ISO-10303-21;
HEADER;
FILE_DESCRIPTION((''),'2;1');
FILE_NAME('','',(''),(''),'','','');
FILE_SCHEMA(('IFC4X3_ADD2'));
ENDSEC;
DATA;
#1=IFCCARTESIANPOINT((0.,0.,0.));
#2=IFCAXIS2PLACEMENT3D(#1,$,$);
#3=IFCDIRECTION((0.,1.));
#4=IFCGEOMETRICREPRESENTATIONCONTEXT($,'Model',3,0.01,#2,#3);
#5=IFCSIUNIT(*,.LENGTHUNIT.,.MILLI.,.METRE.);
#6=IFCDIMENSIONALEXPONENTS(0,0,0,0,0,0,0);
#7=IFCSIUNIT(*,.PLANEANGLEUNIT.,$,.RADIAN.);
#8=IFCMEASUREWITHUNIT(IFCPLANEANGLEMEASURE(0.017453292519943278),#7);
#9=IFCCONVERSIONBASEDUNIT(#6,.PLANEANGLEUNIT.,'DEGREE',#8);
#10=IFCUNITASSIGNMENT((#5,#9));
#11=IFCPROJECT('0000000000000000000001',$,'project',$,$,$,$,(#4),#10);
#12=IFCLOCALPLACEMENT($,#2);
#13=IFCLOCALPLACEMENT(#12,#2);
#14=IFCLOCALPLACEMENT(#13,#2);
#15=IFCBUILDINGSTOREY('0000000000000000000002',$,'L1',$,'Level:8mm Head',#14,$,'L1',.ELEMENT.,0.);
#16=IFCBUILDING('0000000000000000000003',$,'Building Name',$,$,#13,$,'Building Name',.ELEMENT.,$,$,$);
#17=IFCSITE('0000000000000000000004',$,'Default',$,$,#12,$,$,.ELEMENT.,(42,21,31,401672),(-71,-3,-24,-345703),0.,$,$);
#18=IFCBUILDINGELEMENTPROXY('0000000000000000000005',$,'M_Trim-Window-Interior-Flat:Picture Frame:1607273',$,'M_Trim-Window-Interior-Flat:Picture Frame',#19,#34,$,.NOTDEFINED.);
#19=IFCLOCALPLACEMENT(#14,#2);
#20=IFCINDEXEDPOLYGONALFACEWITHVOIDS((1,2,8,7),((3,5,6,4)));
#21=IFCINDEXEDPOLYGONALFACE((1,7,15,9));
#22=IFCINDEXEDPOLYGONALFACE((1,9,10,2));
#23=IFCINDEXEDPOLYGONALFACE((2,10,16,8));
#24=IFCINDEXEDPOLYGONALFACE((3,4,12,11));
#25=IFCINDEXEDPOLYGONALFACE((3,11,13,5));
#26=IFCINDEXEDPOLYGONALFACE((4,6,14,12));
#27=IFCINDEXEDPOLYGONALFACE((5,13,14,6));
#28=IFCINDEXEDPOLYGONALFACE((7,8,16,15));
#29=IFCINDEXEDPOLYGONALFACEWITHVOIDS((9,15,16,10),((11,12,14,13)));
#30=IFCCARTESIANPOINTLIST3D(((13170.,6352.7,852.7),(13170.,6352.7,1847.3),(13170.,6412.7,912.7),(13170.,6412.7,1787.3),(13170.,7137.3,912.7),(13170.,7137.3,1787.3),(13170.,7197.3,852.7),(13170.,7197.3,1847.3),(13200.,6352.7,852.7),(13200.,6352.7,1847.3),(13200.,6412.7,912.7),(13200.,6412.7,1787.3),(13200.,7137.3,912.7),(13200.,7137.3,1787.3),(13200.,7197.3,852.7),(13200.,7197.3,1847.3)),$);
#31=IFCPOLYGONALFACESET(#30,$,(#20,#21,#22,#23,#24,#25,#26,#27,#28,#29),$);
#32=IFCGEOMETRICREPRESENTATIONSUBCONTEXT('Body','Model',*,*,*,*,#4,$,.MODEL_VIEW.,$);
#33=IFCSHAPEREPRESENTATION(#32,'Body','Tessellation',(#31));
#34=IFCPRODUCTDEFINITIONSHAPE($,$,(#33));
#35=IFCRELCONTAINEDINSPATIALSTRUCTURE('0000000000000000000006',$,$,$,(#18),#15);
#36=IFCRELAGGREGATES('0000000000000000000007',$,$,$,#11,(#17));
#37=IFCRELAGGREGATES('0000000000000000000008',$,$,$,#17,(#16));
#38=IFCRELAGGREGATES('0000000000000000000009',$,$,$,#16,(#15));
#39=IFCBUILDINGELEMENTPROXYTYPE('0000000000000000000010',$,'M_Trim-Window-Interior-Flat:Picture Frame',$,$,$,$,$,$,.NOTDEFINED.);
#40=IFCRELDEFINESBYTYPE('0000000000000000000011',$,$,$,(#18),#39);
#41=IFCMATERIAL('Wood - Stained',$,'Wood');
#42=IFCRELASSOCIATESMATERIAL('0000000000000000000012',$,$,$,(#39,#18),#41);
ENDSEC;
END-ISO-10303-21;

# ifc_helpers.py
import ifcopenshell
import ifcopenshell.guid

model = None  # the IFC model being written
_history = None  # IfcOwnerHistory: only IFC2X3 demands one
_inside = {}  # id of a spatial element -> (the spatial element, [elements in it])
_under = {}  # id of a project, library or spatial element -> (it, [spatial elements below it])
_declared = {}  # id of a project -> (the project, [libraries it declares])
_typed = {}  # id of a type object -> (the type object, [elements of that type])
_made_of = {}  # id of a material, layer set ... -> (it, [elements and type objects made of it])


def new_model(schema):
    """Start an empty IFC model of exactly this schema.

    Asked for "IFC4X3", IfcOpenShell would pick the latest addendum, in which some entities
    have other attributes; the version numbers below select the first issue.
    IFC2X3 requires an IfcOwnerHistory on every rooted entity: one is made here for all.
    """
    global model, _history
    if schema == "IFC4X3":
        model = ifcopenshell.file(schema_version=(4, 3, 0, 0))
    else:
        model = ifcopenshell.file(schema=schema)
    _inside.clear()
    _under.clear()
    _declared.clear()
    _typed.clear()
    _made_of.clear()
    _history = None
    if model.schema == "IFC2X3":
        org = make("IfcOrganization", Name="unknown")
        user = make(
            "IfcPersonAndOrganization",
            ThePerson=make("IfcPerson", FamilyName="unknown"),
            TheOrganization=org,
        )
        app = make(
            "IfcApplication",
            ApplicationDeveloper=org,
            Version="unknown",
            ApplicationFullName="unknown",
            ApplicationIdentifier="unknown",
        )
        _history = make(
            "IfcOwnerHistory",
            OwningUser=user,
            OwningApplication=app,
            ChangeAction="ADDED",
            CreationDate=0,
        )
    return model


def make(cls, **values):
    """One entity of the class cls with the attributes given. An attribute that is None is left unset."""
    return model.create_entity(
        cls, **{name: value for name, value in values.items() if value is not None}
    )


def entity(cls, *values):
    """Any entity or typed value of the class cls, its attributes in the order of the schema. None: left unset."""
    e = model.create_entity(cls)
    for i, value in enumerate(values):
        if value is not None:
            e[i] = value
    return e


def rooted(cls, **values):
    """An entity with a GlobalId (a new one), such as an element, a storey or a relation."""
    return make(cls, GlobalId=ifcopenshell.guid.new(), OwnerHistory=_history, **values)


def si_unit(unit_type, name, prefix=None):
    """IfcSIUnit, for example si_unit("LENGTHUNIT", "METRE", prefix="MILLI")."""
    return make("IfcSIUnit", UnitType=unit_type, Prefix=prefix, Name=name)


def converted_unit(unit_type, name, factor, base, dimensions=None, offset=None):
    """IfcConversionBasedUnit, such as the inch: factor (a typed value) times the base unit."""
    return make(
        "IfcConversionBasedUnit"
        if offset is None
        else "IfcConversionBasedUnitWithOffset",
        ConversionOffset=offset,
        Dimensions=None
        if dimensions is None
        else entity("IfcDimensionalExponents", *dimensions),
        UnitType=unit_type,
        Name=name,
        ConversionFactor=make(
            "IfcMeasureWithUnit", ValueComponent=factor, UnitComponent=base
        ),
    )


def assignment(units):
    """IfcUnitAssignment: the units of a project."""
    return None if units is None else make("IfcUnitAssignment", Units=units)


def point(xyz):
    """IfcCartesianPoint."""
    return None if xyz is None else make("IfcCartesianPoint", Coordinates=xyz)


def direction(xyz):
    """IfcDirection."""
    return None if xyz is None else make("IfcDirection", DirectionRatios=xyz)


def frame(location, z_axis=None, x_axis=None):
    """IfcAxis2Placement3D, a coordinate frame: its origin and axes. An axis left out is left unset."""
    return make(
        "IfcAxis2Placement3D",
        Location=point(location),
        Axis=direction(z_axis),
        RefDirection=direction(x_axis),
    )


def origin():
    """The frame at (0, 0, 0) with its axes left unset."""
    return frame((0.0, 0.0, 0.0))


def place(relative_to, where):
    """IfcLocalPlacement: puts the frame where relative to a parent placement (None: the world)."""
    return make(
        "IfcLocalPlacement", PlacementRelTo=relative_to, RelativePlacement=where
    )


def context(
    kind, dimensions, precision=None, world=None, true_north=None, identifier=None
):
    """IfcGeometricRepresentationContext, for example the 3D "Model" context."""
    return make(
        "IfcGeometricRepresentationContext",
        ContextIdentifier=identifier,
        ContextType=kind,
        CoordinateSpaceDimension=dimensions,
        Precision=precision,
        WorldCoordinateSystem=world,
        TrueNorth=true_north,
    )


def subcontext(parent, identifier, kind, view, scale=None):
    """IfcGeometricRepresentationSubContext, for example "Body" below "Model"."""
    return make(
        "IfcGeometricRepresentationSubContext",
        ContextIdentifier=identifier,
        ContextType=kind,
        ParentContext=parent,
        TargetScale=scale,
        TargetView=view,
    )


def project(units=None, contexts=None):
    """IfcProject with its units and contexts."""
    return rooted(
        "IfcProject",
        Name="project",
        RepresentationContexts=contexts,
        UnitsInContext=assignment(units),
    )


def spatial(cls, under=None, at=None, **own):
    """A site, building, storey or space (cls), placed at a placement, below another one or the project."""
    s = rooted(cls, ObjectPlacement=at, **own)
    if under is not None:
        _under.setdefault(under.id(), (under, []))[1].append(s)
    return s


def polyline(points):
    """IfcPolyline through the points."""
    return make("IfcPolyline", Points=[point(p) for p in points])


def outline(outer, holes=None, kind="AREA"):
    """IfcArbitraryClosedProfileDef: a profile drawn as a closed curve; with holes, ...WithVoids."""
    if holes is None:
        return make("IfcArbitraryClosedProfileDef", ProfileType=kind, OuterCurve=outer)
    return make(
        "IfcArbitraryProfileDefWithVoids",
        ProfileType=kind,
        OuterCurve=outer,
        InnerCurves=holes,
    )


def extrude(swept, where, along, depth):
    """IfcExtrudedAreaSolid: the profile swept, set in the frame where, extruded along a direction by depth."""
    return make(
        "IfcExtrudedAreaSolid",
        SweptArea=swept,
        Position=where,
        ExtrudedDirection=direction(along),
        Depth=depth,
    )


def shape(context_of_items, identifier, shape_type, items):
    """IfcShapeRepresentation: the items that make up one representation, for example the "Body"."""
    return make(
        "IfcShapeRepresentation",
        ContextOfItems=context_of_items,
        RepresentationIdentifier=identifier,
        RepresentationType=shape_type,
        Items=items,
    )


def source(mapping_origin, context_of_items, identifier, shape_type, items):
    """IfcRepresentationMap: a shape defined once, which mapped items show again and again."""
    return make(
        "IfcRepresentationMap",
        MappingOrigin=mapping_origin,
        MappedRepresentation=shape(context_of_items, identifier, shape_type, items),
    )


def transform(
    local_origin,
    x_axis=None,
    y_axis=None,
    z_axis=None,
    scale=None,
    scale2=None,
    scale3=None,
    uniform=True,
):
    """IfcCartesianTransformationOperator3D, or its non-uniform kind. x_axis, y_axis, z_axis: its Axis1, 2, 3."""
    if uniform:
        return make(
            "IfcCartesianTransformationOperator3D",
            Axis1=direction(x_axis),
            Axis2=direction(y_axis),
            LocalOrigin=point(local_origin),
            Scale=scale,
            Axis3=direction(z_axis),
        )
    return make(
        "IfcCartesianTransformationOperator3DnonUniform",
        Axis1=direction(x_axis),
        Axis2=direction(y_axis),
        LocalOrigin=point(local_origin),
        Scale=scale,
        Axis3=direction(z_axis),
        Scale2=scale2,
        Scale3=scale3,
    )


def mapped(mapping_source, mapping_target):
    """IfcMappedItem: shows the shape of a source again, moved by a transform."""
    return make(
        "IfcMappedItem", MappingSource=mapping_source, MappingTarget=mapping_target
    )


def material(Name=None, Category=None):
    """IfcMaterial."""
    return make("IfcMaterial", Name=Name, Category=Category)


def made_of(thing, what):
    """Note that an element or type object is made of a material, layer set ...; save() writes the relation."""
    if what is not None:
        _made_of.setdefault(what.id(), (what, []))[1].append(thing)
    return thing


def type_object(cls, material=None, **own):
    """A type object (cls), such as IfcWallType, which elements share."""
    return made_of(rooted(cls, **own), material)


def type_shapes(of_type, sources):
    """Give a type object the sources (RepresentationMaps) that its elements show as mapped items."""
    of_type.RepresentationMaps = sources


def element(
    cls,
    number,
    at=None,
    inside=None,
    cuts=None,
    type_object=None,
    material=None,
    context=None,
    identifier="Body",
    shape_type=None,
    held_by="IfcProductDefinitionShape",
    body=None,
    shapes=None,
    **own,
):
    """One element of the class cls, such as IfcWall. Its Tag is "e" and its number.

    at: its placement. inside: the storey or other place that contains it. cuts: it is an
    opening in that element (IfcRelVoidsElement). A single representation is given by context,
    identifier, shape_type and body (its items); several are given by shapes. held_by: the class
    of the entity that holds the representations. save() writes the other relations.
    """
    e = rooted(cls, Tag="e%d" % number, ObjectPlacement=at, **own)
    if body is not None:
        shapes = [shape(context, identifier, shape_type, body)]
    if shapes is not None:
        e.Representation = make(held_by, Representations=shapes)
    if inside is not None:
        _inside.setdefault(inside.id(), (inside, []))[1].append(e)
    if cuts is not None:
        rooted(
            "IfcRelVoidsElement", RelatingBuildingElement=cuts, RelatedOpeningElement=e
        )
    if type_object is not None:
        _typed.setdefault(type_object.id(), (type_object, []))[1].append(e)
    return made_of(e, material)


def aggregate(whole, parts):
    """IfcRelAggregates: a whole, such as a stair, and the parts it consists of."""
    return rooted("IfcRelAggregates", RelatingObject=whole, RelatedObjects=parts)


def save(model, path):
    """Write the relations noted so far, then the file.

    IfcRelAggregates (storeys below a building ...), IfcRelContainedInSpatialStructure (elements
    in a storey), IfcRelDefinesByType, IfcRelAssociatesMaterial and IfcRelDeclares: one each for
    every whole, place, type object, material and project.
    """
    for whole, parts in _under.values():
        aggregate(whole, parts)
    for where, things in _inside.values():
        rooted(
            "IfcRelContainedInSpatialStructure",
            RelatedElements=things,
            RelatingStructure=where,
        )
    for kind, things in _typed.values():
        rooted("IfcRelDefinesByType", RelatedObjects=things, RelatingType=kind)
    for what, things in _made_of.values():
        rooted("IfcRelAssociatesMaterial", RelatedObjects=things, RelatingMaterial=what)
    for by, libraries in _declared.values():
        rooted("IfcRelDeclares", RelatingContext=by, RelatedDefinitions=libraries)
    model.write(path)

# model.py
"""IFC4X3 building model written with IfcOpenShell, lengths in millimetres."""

from ifc_helpers import new_model, entity, si_unit, converted_unit, direction, frame, origin, place, context, subcontext, project, spatial, polyline, outline, extrude, source, transform, mapped, material, type_object, type_shapes, element, save


model = new_model("IFC4X3")

# Units and contexts
model_context = context("Model", 3, precision=0.01, world=origin(), true_north=direction((0.0, 1.0)))
body_context = subcontext(model_context, "Body", "Model", "MODEL_VIEW")
ifc_project = project(units=[si_unit("LENGTHUNIT", "METRE", prefix="MILLI"), converted_unit("PLANEANGLEUNIT", "DEGREE", entity("IfcPlaneAngleMeasure", 0.017453292519943278), si_unit("PLANEANGLEUNIT", "RADIAN"), dimensions=[0, 0, 0, 0, 0, 0, 0])], contexts=[model_context])

# Site, building, storey
site_placement = place(None, origin())
site = spatial("IfcSite", under=ifc_project, at=site_placement, Name="Default", CompositionType="ELEMENT", RefLatitude=(42, 21, 31, 401672), RefLongitude=(-71, -3, -24, -345703), RefElevation=0.0)
building_placement = place(site_placement, origin())
building = spatial("IfcBuilding", under=site, at=building_placement, Name="Building Name", LongName="Building Name", CompositionType="ELEMENT")
storey_placement = place(building_placement, origin())
storey = spatial("IfcBuildingStorey", under=building, at=storey_placement, Name="L1", ObjectType="Level:8mm Head", LongName="L1", CompositionType="ELEMENT", Elevation=0.0)

# Building element proxy
ifc_material_1 = material(Name="Wood - Stained", Category="Wood")
building_element_proxy_type_1 = type_object("IfcBuildingElementProxyType", Name="M_Trim-Window-Interior-Flat:Picture Frame", PredefinedType="NOTDEFINED", material=ifc_material_1)
shared_shape_1 = source(origin(), body_context, "Body", "SweptSolid", [
    extrude(outline(polyline([(-422.3, -497.3), (422.3, -497.3), (422.3, 497.3), (-422.3, 497.3), (-422.3, -497.3)]), holes=[polyline([(-362.3, -437.3), (-362.3, 437.3), (362.3, 437.3), (362.3, -437.3), (-362.3, -437.3)])]), frame((0.0, -450.0, 0.0), z_axis=(0.0, 0.0, 1.0), x_axis=(-1.0, 0.0, 0.0)), (0.0, 0.0, 1.0), 30.0),
])
type_shapes(building_element_proxy_type_1, [shared_shape_1])
for number, where, z_axis, x_axis, name in (
    (1, (13200.0, 6775.0, 1800.0), (-1.0, 0.0, 0.0), (0.0, -1.0, 0.0), "M_Trim-Window-Interior-Flat:Picture Frame:1607273"),
):
    element("IfcBuildingElementProxy", number, at=place(storey_placement, frame(where, z_axis=z_axis, x_axis=x_axis)), inside=storey, type_object=building_element_proxy_type_1, material=ifc_material_1, Name=name, ObjectType="M_Trim-Window-Interior-Flat:Picture Frame", PredefinedType="NOTDEFINED", context=body_context, shape_type="MappedRepresentation", body=[
        mapped(shared_shape_1, transform((0.0, 0.0, 0.0), scale=1.0)),
    ])

save(model, "model.ifc")
